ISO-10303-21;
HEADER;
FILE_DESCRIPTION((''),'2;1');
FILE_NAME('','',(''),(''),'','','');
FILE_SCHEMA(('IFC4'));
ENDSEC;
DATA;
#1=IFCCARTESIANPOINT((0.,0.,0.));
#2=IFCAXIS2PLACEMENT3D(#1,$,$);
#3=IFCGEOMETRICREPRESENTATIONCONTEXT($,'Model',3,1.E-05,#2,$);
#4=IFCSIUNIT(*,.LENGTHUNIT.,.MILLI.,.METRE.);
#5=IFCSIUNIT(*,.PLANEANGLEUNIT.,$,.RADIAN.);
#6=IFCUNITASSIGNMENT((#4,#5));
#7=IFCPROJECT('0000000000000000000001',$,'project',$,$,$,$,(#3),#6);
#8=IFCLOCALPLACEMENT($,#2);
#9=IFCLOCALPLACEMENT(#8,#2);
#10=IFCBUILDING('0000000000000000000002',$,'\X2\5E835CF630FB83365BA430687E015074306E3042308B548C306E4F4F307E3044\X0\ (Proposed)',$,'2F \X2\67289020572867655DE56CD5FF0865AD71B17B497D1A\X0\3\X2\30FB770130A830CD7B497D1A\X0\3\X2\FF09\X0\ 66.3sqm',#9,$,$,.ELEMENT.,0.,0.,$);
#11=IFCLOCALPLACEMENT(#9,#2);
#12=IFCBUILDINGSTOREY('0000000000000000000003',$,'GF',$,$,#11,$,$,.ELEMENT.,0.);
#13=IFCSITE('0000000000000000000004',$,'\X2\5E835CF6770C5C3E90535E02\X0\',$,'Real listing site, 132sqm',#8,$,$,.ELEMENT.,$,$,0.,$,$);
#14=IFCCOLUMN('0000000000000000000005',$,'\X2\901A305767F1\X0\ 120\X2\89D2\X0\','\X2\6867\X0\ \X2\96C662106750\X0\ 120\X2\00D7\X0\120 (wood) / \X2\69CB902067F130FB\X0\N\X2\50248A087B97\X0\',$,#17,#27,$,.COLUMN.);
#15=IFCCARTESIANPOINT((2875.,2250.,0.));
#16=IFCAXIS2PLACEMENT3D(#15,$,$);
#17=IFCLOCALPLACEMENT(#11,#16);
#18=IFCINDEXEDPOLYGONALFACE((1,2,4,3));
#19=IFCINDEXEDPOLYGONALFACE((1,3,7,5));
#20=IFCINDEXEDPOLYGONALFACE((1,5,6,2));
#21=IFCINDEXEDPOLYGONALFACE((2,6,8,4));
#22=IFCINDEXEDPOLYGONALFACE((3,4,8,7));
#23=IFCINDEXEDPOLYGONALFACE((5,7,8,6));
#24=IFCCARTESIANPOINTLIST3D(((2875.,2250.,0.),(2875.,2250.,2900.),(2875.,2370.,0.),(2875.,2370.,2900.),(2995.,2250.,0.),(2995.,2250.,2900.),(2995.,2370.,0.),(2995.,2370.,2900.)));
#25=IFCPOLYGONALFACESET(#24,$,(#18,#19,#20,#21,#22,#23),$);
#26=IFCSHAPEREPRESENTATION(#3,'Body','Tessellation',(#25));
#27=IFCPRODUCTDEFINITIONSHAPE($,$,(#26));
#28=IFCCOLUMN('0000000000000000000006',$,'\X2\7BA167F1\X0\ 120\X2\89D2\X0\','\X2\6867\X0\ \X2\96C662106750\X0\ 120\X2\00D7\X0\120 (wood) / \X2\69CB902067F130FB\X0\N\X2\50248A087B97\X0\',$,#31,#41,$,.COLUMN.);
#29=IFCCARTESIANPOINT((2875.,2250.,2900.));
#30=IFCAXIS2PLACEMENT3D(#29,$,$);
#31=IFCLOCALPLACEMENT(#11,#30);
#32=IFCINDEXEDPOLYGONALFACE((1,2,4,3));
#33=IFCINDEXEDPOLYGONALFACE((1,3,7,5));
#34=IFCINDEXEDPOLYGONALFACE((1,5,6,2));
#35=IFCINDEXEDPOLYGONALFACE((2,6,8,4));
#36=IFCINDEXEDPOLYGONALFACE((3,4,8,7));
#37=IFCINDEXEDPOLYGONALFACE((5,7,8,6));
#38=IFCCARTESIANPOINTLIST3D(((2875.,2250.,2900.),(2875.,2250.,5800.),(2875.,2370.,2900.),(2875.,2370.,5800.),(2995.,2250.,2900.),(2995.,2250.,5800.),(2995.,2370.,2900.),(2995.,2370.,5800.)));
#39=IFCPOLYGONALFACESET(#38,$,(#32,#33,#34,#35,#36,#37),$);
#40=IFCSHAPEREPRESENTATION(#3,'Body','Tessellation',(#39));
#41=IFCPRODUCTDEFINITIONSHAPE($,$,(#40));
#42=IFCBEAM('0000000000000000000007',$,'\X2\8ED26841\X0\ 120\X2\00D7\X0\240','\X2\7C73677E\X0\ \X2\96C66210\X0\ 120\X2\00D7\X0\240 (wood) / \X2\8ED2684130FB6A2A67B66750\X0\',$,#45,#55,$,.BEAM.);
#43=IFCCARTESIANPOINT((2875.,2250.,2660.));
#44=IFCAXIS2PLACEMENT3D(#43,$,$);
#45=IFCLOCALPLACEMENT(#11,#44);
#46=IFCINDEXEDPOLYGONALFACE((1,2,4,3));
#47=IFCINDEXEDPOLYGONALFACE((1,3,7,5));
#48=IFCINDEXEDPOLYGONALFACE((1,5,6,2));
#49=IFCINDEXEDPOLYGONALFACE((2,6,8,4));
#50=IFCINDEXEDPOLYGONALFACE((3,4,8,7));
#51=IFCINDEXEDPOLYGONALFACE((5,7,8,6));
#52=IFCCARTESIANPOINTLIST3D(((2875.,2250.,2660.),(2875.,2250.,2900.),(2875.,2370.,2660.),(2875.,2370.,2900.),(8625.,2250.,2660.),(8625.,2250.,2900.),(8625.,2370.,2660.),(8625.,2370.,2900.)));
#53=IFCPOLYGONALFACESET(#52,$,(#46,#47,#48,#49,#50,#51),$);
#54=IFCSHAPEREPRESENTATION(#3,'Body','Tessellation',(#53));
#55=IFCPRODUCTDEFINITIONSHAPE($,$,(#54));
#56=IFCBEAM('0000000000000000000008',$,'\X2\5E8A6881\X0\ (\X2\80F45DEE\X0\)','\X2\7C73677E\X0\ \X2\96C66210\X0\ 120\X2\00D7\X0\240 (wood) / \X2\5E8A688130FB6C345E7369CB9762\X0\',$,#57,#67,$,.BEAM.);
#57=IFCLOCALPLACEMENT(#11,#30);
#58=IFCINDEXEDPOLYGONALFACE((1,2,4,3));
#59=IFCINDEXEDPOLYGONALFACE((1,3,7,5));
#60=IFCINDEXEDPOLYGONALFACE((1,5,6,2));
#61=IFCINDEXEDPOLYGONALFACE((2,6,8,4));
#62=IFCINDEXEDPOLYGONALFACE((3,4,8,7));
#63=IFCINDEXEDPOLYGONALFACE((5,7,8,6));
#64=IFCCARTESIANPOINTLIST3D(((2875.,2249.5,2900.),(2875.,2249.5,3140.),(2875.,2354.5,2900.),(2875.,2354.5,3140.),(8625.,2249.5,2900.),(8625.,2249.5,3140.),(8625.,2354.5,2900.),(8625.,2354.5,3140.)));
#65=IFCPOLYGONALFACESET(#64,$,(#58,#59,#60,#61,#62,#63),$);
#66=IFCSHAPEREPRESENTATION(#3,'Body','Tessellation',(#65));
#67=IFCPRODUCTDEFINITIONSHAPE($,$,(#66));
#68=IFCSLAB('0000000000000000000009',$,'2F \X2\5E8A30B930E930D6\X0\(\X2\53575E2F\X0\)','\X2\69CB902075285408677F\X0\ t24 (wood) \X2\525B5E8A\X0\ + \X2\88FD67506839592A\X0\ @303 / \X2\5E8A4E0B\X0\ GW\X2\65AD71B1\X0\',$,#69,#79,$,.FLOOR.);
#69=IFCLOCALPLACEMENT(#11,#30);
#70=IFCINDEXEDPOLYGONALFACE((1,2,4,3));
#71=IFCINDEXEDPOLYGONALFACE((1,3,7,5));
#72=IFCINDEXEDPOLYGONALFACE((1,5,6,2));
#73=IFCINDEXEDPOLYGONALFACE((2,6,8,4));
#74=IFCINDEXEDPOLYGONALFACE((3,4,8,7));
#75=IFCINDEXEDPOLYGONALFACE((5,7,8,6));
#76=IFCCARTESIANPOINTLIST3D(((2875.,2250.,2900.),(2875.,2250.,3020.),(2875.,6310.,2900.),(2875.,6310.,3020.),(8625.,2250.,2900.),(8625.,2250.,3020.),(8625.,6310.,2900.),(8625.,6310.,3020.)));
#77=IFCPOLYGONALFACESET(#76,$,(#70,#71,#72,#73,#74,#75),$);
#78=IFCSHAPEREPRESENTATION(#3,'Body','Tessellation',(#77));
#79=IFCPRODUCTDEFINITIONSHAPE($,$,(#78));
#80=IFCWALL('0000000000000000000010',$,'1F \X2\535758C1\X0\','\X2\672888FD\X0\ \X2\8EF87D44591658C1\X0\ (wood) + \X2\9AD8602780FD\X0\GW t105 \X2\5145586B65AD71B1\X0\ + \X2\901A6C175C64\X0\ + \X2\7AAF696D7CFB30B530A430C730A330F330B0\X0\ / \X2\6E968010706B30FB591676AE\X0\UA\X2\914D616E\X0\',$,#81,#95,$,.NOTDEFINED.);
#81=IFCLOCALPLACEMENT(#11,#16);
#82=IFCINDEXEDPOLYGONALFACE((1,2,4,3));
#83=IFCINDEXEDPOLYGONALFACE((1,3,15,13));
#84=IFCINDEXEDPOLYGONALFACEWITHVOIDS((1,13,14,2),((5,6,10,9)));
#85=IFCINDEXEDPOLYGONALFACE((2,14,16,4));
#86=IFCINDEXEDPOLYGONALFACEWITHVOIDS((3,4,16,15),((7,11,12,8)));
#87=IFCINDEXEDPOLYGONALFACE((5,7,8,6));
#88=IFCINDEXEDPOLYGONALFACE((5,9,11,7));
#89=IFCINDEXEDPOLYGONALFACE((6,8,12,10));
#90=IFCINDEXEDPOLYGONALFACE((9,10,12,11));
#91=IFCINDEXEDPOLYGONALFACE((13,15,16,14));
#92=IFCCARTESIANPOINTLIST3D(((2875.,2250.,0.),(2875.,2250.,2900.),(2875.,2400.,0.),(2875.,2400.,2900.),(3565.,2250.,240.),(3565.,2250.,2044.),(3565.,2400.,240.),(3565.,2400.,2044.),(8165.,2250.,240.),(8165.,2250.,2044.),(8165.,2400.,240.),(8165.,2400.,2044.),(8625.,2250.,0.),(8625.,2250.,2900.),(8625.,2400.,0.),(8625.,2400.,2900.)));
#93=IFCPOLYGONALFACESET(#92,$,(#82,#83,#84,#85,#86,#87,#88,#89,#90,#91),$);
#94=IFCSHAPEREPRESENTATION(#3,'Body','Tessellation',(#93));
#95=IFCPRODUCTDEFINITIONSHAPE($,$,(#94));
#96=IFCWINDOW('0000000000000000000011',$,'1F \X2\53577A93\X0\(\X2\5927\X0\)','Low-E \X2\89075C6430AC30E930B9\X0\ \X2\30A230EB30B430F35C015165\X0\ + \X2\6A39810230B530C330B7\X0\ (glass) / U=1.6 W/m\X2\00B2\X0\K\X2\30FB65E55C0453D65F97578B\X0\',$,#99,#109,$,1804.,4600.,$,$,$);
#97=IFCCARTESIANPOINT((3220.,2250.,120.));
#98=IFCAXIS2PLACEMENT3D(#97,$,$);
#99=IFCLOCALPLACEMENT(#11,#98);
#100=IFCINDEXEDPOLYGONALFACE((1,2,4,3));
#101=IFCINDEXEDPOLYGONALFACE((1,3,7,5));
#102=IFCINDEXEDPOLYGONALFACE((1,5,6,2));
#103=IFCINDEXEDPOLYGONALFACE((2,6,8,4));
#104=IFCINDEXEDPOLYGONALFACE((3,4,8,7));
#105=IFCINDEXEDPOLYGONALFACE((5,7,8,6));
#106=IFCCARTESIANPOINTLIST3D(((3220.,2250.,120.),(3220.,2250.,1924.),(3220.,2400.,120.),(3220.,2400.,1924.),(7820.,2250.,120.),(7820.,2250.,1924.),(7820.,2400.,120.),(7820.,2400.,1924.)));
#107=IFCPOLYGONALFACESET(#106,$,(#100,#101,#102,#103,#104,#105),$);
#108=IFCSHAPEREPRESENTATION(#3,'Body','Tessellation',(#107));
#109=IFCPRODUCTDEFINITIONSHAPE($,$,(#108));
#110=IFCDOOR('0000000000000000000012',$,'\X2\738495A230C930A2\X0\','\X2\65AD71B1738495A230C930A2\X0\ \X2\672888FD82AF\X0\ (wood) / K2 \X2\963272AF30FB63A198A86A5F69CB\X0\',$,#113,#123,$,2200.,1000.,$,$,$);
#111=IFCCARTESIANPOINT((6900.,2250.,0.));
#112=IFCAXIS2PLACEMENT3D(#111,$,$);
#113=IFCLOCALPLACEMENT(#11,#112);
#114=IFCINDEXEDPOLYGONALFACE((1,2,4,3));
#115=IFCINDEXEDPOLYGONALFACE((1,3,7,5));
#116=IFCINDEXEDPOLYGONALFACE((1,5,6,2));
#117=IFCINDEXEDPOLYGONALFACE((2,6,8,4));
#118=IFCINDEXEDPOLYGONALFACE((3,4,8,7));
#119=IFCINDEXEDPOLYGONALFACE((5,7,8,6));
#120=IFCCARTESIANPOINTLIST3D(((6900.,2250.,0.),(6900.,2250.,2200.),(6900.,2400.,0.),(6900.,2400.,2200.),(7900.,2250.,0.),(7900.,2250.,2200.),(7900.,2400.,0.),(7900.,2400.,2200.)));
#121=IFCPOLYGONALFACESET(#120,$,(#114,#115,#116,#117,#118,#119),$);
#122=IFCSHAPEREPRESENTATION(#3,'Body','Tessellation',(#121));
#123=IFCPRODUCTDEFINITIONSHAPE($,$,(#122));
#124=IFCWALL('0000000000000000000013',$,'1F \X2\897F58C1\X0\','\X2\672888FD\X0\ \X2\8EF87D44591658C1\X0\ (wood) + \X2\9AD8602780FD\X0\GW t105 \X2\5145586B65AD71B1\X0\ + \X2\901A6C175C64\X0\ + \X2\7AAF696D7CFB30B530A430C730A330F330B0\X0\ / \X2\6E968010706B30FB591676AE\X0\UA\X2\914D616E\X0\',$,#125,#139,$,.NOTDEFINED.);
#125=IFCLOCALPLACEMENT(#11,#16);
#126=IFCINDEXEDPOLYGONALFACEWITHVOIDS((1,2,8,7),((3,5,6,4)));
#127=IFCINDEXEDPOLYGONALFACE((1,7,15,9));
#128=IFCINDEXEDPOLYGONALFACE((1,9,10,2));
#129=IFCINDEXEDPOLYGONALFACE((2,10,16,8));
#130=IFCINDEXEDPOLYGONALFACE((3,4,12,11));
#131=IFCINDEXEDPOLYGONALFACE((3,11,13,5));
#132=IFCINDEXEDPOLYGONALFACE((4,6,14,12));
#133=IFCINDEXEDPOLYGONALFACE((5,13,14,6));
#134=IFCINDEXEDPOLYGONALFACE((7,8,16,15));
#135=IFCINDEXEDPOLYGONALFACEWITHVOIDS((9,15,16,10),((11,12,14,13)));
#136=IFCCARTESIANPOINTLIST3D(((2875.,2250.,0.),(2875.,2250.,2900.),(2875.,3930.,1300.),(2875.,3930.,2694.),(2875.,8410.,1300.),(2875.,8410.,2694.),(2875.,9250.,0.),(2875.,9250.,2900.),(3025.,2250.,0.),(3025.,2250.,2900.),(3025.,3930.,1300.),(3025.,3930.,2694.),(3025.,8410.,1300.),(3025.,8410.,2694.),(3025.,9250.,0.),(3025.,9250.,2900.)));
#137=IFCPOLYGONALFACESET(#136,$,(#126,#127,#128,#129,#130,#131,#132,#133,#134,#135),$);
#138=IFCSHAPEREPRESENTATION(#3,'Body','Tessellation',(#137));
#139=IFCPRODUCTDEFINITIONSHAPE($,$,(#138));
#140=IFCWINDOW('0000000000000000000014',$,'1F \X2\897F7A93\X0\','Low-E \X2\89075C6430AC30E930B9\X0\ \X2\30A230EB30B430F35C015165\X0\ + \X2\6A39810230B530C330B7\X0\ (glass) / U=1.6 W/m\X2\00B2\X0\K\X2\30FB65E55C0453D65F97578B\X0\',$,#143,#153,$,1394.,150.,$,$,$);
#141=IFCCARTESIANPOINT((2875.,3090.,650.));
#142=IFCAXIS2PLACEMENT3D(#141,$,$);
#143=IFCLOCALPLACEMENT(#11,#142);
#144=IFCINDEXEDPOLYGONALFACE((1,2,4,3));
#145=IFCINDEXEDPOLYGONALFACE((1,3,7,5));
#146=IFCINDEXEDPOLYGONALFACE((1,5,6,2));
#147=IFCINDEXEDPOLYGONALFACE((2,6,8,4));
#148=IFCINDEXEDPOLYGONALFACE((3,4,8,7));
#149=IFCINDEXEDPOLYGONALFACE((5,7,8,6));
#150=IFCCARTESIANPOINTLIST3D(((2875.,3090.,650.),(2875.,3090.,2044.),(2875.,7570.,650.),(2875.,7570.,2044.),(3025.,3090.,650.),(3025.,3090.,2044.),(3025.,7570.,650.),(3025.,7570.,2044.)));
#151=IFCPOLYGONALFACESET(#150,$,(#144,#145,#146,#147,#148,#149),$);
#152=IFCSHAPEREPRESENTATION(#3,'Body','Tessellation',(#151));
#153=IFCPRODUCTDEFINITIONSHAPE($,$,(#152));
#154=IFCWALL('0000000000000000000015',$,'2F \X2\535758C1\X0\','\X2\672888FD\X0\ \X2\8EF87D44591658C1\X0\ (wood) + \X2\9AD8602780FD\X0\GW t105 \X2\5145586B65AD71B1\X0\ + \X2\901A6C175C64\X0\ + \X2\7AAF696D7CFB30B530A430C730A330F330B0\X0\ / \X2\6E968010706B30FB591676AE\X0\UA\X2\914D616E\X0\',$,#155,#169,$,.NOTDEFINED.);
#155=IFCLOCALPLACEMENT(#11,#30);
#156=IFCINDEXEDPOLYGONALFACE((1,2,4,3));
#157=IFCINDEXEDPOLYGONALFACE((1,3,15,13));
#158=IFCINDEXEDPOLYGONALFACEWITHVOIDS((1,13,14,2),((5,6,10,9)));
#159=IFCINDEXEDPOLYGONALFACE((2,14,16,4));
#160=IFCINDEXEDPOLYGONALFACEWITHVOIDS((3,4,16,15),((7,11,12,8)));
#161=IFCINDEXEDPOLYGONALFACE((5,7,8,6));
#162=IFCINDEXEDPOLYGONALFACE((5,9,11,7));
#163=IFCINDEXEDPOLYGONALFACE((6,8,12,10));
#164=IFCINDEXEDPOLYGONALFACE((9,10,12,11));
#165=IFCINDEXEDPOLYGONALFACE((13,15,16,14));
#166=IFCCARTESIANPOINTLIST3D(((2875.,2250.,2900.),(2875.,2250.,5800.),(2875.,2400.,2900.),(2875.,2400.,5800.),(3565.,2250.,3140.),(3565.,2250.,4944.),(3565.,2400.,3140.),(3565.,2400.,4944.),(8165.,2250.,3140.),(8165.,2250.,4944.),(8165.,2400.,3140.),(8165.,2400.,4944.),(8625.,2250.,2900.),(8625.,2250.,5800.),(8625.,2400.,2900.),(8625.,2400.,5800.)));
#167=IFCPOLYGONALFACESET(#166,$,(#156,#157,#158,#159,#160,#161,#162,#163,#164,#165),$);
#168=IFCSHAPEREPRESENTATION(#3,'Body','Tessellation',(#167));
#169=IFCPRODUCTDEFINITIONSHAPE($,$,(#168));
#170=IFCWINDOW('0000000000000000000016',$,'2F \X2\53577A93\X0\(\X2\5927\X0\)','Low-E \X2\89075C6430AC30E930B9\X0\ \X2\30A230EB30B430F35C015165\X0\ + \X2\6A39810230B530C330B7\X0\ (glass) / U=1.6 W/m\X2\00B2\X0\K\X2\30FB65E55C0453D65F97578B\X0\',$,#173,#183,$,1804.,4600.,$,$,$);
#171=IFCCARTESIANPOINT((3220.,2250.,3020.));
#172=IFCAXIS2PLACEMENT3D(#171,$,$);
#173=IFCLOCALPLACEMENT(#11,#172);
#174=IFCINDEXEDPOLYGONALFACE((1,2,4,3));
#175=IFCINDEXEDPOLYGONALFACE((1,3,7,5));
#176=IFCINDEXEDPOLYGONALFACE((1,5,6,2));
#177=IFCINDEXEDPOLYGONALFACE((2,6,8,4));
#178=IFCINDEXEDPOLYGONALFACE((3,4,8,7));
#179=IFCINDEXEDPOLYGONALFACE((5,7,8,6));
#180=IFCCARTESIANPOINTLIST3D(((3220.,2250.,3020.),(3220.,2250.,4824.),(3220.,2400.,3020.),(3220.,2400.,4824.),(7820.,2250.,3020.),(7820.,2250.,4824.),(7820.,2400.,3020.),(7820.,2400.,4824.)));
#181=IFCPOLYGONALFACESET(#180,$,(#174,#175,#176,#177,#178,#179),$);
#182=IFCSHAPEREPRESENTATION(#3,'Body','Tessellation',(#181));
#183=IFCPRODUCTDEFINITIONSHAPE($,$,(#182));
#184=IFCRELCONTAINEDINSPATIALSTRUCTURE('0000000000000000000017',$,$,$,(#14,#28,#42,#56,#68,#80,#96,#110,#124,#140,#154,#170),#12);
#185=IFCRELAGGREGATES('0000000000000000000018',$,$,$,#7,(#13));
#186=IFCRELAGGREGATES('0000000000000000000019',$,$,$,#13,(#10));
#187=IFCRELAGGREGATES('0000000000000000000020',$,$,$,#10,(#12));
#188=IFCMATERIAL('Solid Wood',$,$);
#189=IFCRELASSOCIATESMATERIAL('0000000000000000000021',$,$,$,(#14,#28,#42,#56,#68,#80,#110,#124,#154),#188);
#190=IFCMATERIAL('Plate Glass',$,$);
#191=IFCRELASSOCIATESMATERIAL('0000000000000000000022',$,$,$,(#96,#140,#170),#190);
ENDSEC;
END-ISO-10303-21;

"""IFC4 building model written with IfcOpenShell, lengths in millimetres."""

from ifc_helpers import new_model, si_unit, frame, frame_2d, origin, place, context, project, spatial, rectangle, extrude, material, element, fill, save


model = new_model("IFC4")

# Units and contexts
model_context = context("Model", 3, precision=1e-05, world=origin())
ifc_project = project(units=[si_unit("LENGTHUNIT", "METRE", prefix="MILLI"), si_unit("PLANEANGLEUNIT", "RADIAN")], contexts=[model_context])

# Site, building, storey
site_placement = place(None, origin())
site = spatial("IfcSite", under=ifc_project, at=site_placement, Name="広島県尾道市", ObjectType="Real listing site, 132sqm", CompositionType="ELEMENT", RefElevation=0.0)
building_placement = place(site_placement, origin())
building = spatial("IfcBuilding", under=site, at=building_placement, Name="広島・茶室と縁側のある和の住まい (Proposed)", ObjectType="2F 木造在来工法（断熱等級3・省エネ等級3） 66.3sqm", CompositionType="ELEMENT", ElevationOfRefHeight=0.0, ElevationOfTerrain=0.0)
storey_placement = place(building_placement, origin())
storey = spatial("IfcBuildingStorey", under=building, at=storey_placement, Name="GF", CompositionType="ELEMENT", Elevation=0.0)

# Columns
ifc_material_1 = material(Name="Solid Wood")
column_1_placement = place(storey_placement, frame((2875.0, 2250.0, 0.0)))
element("IfcColumn", 1, at=column_1_placement, inside=storey, material=ifc_material_1, Name="通し柱 120角", Description="桧 集成材 120×120 (wood) / 構造柱・N値計算", PredefinedType="COLUMN", context=model_context, shape_type="SweptSolid", body=[
    extrude(rectangle(XDim=120.0, YDim=120.0, at=frame_2d((60.0, 60.0))), frame((2875.0, 2250.0, 0.0)), (0.0, 0.0, 1.0), 2900.0),
])
column_2_placement = place(storey_placement, frame((2875.0, 2250.0, 2900.0)))
element("IfcColumn", 2, at=column_2_placement, inside=storey, material=ifc_material_1, Name="管柱 120角", Description="桧 集成材 120×120 (wood) / 構造柱・N値計算", PredefinedType="COLUMN", context=model_context, shape_type="SweptSolid", body=[
    extrude(rectangle(XDim=120.0, YDim=120.0, at=frame_2d((60.0, 60.0))), frame((2875.0, 2250.0, 2900.0)), (0.0, 0.0, 1.0), 2900.0),
])

# Beams
beam_1_placement = place(storey_placement, frame((2875.0, 2250.0, 2660.0)))
element("IfcBeam", 3, at=beam_1_placement, inside=storey, material=ifc_material_1, Name="軒桁 120×240", Description="米松 集成 120×240 (wood) / 軒桁・横架材", PredefinedType="BEAM", context=model_context, shape_type="SweptSolid", body=[
    extrude(rectangle(XDim=5750.0, YDim=120.0, at=frame_2d((2875.0, 60.0))), frame((2875.0, 2250.0, 2660.0)), (0.0, 0.0, 1.0), 240.0),
])
beam_2_placement = place(storey_placement, frame((2875.0, 2250.0, 2900.0)))
element("IfcBeam", 4, at=beam_2_placement, inside=storey, material=ifc_material_1, Name="床梁 (胴差)", Description="米松 集成 120×240 (wood) / 床梁・水平構面", PredefinedType="BEAM", context=model_context, shape_type="SweptSolid", body=[
    extrude(rectangle(XDim=5750.0, YDim=105.0, at=frame_2d((2875.0, 52.0))), frame((2875.0, 2250.0, 2900.0)), (0.0, 0.0, 1.0), 240.0),
])

# Slab
slab_1_placement = place(storey_placement, frame((2875.0, 2250.0, 2900.0)))
element("IfcSlab", 5, at=slab_1_placement, inside=storey, material=ifc_material_1, Name="2F 床スラブ(南帯)", Description="構造用合板 t24 (wood) 剛床 + 製材根太 @303 / 床下 GW断熱", PredefinedType="FLOOR", context=model_context, shape_type="SweptSolid", body=[
    extrude(rectangle(XDim=5750.0, YDim=4060.0, at=frame_2d((2875.0, 2030.0))), frame((2875.0, 2250.0, 2900.0)), (0.0, 0.0, 1.0), 120.0),
])

# Wall, openings, window, door
wall_1_placement = place(storey_placement, frame((2875.0, 2250.0, 0.0)))
wall_1 = element("IfcWall", 6, at=wall_1_placement, inside=storey, material=ifc_material_1, Name="1F 南壁", Description="木製 軸組外壁 (wood) + 高性能GW t105 充填断熱 + 通気層 + 窯業系サイディング / 準耐火・外皮UA配慮", PredefinedType="NOTDEFINED", context=model_context, shape_type="SweptSolid", body=[
    extrude(rectangle(XDim=5750.0, YDim=150.0, at=frame_2d((2875.0, 75.0))), frame((2875.0, 2250.0, 0.0)), (0.0, 0.0, 1.0), 2900.0),
])
opening_1_placement = place(storey_placement, frame((3220.0, 2250.0, 120.0)))
opening_1 = element("IfcOpeningElement", 7, at=opening_1_placement, cuts=wall_1, PredefinedType="NOTDEFINED", context=model_context, shape_type="SweptSolid", body=[
    extrude(rectangle(XDim=4600.0, YDim=150.0, at=frame_2d((2300.0, 75.0))), frame((3220.0, 2250.0, 120.0)), (0.0, 0.0, 1.0), 1804.0),
])
opening_2_placement = place(storey_placement, frame((6900.0, 2250.0, 0.0)))
opening_2 = element("IfcOpeningElement", 8, at=opening_2_placement, cuts=wall_1, PredefinedType="NOTDEFINED", context=model_context, shape_type="SweptSolid", body=[
    extrude(rectangle(XDim=1000.0, YDim=150.0, at=frame_2d((500.0, 75.0))), frame((6900.0, 2250.0, 0.0)), (0.0, 0.0, 1.0), 2200.0),
])
ifc_material_2 = material(Name="Plate Glass")
window_1_placement = place(storey_placement, frame((3220.0, 2250.0, 120.0)))
window_1 = element("IfcWindow", 9, at=window_1_placement, inside=storey, material=ifc_material_2, Name="1F 南窓(大)", Description="Low-E 複層ガラス アルゴン封入 + 樹脂サッシ (glass) / U=1.6 W/m²K・日射取得型", OverallHeight=1804.0, OverallWidth=4600.0, context=model_context, shape_type="SweptSolid", body=[
    extrude(rectangle(XDim=4600.0, YDim=150.0, at=frame_2d((2300.0, 75.0))), frame((3220.0, 2250.0, 120.0)), (0.0, 0.0, 1.0), 1804.0),
])
fill(opening_1, window_1)
door_placement = place(storey_placement, frame((6900.0, 2250.0, 0.0)))
door = element("IfcDoor", 10, at=door_placement, inside=storey, material=ifc_material_1, Name="玄関ドア", Description="断熱玄関ドア 木製芯 (wood) / K2 防犯・採風機構", OverallHeight=2200.0, OverallWidth=1000.0, context=model_context, shape_type="SweptSolid", body=[
    extrude(rectangle(XDim=1000.0, YDim=150.0, at=frame_2d((500.0, 75.0))), frame((6900.0, 2250.0, 0.0)), (0.0, 0.0, 1.0), 2200.0),
])
fill(opening_2, door)

# Walls, openings, windows
wall_2_placement = place(storey_placement, frame((2875.0, 2250.0, 0.0)))
wall_2 = element("IfcWall", 11, at=wall_2_placement, inside=storey, material=ifc_material_1, Name="1F 西壁", Description="木製 軸組外壁 (wood) + 高性能GW t105 充填断熱 + 通気層 + 窯業系サイディング / 準耐火・外皮UA配慮", PredefinedType="NOTDEFINED", context=model_context, shape_type="SweptSolid", body=[
    extrude(rectangle(XDim=150.0, YDim=7000.0, at=frame_2d((75.0, 3500.0))), frame((2875.0, 2250.0, 0.0)), (0.0, 0.0, 1.0), 2900.0),
])
opening_3_placement = place(storey_placement, frame((2875.0, 3090.0, 650.0)))
opening_3 = element("IfcOpeningElement", 12, at=opening_3_placement, cuts=wall_2, PredefinedType="NOTDEFINED", context=model_context, shape_type="SweptSolid", body=[
    extrude(rectangle(XDim=150.0, YDim=4480.0, at=frame_2d((75.0, 2240.0))), frame((2875.0, 3090.0, 650.0)), (0.0, 0.0, 1.0), 1394.0),
])
window_2_placement = place(storey_placement, frame((2875.0, 3090.0, 650.0)))
window_2 = element("IfcWindow", 13, at=window_2_placement, inside=storey, material=ifc_material_2, Name="1F 西窓", Description="Low-E 複層ガラス アルゴン封入 + 樹脂サッシ (glass) / U=1.6 W/m²K・日射取得型", OverallHeight=1394.0, OverallWidth=150.0, context=model_context, shape_type="SweptSolid", body=[
    extrude(rectangle(XDim=150.0, YDim=4480.0, at=frame_2d((75.0, 2240.0))), frame((2875.0, 3090.0, 650.0)), (0.0, 0.0, 1.0), 1394.0),
])
fill(opening_3, window_2)
wall_3_placement = place(storey_placement, frame((2875.0, 2250.0, 2900.0)))
wall_3 = element("IfcWall", 14, at=wall_3_placement, inside=storey, material=ifc_material_1, Name="2F 南壁", Description="木製 軸組外壁 (wood) + 高性能GW t105 充填断熱 + 通気層 + 窯業系サイディング / 準耐火・外皮UA配慮", PredefinedType="NOTDEFINED", context=model_context, shape_type="SweptSolid", body=[
    extrude(rectangle(XDim=5750.0, YDim=150.0, at=frame_2d((2875.0, 75.0))), frame((2875.0, 2250.0, 2900.0)), (0.0, 0.0, 1.0), 2900.0),
])
opening_4_placement = place(storey_placement, frame((3220.0, 2250.0, 3020.0)))
opening_4 = element("IfcOpeningElement", 15, at=opening_4_placement, cuts=wall_3, PredefinedType="NOTDEFINED", context=model_context, shape_type="SweptSolid", body=[
    extrude(rectangle(XDim=4600.0, YDim=150.0, at=frame_2d((2300.0, 75.0))), frame((3220.0, 2250.0, 3020.0)), (0.0, 0.0, 1.0), 1804.0),
])
window_3_placement = place(storey_placement, frame((3220.0, 2250.0, 3020.0)))
window_3 = element("IfcWindow", 16, at=window_3_placement, inside=storey, material=ifc_material_2, Name="2F 南窓(大)", Description="Low-E 複層ガラス アルゴン封入 + 樹脂サッシ (glass) / U=1.6 W/m²K・日射取得型", OverallHeight=1804.0, OverallWidth=4600.0, context=model_context, shape_type="SweptSolid", body=[
    extrude(rectangle(XDim=4600.0, YDim=150.0, at=frame_2d((2300.0, 75.0))), frame((3220.0, 2250.0, 3020.0)), (0.0, 0.0, 1.0), 1804.0),
])
fill(opening_4, window_3)

save(model, "model.ifc")
